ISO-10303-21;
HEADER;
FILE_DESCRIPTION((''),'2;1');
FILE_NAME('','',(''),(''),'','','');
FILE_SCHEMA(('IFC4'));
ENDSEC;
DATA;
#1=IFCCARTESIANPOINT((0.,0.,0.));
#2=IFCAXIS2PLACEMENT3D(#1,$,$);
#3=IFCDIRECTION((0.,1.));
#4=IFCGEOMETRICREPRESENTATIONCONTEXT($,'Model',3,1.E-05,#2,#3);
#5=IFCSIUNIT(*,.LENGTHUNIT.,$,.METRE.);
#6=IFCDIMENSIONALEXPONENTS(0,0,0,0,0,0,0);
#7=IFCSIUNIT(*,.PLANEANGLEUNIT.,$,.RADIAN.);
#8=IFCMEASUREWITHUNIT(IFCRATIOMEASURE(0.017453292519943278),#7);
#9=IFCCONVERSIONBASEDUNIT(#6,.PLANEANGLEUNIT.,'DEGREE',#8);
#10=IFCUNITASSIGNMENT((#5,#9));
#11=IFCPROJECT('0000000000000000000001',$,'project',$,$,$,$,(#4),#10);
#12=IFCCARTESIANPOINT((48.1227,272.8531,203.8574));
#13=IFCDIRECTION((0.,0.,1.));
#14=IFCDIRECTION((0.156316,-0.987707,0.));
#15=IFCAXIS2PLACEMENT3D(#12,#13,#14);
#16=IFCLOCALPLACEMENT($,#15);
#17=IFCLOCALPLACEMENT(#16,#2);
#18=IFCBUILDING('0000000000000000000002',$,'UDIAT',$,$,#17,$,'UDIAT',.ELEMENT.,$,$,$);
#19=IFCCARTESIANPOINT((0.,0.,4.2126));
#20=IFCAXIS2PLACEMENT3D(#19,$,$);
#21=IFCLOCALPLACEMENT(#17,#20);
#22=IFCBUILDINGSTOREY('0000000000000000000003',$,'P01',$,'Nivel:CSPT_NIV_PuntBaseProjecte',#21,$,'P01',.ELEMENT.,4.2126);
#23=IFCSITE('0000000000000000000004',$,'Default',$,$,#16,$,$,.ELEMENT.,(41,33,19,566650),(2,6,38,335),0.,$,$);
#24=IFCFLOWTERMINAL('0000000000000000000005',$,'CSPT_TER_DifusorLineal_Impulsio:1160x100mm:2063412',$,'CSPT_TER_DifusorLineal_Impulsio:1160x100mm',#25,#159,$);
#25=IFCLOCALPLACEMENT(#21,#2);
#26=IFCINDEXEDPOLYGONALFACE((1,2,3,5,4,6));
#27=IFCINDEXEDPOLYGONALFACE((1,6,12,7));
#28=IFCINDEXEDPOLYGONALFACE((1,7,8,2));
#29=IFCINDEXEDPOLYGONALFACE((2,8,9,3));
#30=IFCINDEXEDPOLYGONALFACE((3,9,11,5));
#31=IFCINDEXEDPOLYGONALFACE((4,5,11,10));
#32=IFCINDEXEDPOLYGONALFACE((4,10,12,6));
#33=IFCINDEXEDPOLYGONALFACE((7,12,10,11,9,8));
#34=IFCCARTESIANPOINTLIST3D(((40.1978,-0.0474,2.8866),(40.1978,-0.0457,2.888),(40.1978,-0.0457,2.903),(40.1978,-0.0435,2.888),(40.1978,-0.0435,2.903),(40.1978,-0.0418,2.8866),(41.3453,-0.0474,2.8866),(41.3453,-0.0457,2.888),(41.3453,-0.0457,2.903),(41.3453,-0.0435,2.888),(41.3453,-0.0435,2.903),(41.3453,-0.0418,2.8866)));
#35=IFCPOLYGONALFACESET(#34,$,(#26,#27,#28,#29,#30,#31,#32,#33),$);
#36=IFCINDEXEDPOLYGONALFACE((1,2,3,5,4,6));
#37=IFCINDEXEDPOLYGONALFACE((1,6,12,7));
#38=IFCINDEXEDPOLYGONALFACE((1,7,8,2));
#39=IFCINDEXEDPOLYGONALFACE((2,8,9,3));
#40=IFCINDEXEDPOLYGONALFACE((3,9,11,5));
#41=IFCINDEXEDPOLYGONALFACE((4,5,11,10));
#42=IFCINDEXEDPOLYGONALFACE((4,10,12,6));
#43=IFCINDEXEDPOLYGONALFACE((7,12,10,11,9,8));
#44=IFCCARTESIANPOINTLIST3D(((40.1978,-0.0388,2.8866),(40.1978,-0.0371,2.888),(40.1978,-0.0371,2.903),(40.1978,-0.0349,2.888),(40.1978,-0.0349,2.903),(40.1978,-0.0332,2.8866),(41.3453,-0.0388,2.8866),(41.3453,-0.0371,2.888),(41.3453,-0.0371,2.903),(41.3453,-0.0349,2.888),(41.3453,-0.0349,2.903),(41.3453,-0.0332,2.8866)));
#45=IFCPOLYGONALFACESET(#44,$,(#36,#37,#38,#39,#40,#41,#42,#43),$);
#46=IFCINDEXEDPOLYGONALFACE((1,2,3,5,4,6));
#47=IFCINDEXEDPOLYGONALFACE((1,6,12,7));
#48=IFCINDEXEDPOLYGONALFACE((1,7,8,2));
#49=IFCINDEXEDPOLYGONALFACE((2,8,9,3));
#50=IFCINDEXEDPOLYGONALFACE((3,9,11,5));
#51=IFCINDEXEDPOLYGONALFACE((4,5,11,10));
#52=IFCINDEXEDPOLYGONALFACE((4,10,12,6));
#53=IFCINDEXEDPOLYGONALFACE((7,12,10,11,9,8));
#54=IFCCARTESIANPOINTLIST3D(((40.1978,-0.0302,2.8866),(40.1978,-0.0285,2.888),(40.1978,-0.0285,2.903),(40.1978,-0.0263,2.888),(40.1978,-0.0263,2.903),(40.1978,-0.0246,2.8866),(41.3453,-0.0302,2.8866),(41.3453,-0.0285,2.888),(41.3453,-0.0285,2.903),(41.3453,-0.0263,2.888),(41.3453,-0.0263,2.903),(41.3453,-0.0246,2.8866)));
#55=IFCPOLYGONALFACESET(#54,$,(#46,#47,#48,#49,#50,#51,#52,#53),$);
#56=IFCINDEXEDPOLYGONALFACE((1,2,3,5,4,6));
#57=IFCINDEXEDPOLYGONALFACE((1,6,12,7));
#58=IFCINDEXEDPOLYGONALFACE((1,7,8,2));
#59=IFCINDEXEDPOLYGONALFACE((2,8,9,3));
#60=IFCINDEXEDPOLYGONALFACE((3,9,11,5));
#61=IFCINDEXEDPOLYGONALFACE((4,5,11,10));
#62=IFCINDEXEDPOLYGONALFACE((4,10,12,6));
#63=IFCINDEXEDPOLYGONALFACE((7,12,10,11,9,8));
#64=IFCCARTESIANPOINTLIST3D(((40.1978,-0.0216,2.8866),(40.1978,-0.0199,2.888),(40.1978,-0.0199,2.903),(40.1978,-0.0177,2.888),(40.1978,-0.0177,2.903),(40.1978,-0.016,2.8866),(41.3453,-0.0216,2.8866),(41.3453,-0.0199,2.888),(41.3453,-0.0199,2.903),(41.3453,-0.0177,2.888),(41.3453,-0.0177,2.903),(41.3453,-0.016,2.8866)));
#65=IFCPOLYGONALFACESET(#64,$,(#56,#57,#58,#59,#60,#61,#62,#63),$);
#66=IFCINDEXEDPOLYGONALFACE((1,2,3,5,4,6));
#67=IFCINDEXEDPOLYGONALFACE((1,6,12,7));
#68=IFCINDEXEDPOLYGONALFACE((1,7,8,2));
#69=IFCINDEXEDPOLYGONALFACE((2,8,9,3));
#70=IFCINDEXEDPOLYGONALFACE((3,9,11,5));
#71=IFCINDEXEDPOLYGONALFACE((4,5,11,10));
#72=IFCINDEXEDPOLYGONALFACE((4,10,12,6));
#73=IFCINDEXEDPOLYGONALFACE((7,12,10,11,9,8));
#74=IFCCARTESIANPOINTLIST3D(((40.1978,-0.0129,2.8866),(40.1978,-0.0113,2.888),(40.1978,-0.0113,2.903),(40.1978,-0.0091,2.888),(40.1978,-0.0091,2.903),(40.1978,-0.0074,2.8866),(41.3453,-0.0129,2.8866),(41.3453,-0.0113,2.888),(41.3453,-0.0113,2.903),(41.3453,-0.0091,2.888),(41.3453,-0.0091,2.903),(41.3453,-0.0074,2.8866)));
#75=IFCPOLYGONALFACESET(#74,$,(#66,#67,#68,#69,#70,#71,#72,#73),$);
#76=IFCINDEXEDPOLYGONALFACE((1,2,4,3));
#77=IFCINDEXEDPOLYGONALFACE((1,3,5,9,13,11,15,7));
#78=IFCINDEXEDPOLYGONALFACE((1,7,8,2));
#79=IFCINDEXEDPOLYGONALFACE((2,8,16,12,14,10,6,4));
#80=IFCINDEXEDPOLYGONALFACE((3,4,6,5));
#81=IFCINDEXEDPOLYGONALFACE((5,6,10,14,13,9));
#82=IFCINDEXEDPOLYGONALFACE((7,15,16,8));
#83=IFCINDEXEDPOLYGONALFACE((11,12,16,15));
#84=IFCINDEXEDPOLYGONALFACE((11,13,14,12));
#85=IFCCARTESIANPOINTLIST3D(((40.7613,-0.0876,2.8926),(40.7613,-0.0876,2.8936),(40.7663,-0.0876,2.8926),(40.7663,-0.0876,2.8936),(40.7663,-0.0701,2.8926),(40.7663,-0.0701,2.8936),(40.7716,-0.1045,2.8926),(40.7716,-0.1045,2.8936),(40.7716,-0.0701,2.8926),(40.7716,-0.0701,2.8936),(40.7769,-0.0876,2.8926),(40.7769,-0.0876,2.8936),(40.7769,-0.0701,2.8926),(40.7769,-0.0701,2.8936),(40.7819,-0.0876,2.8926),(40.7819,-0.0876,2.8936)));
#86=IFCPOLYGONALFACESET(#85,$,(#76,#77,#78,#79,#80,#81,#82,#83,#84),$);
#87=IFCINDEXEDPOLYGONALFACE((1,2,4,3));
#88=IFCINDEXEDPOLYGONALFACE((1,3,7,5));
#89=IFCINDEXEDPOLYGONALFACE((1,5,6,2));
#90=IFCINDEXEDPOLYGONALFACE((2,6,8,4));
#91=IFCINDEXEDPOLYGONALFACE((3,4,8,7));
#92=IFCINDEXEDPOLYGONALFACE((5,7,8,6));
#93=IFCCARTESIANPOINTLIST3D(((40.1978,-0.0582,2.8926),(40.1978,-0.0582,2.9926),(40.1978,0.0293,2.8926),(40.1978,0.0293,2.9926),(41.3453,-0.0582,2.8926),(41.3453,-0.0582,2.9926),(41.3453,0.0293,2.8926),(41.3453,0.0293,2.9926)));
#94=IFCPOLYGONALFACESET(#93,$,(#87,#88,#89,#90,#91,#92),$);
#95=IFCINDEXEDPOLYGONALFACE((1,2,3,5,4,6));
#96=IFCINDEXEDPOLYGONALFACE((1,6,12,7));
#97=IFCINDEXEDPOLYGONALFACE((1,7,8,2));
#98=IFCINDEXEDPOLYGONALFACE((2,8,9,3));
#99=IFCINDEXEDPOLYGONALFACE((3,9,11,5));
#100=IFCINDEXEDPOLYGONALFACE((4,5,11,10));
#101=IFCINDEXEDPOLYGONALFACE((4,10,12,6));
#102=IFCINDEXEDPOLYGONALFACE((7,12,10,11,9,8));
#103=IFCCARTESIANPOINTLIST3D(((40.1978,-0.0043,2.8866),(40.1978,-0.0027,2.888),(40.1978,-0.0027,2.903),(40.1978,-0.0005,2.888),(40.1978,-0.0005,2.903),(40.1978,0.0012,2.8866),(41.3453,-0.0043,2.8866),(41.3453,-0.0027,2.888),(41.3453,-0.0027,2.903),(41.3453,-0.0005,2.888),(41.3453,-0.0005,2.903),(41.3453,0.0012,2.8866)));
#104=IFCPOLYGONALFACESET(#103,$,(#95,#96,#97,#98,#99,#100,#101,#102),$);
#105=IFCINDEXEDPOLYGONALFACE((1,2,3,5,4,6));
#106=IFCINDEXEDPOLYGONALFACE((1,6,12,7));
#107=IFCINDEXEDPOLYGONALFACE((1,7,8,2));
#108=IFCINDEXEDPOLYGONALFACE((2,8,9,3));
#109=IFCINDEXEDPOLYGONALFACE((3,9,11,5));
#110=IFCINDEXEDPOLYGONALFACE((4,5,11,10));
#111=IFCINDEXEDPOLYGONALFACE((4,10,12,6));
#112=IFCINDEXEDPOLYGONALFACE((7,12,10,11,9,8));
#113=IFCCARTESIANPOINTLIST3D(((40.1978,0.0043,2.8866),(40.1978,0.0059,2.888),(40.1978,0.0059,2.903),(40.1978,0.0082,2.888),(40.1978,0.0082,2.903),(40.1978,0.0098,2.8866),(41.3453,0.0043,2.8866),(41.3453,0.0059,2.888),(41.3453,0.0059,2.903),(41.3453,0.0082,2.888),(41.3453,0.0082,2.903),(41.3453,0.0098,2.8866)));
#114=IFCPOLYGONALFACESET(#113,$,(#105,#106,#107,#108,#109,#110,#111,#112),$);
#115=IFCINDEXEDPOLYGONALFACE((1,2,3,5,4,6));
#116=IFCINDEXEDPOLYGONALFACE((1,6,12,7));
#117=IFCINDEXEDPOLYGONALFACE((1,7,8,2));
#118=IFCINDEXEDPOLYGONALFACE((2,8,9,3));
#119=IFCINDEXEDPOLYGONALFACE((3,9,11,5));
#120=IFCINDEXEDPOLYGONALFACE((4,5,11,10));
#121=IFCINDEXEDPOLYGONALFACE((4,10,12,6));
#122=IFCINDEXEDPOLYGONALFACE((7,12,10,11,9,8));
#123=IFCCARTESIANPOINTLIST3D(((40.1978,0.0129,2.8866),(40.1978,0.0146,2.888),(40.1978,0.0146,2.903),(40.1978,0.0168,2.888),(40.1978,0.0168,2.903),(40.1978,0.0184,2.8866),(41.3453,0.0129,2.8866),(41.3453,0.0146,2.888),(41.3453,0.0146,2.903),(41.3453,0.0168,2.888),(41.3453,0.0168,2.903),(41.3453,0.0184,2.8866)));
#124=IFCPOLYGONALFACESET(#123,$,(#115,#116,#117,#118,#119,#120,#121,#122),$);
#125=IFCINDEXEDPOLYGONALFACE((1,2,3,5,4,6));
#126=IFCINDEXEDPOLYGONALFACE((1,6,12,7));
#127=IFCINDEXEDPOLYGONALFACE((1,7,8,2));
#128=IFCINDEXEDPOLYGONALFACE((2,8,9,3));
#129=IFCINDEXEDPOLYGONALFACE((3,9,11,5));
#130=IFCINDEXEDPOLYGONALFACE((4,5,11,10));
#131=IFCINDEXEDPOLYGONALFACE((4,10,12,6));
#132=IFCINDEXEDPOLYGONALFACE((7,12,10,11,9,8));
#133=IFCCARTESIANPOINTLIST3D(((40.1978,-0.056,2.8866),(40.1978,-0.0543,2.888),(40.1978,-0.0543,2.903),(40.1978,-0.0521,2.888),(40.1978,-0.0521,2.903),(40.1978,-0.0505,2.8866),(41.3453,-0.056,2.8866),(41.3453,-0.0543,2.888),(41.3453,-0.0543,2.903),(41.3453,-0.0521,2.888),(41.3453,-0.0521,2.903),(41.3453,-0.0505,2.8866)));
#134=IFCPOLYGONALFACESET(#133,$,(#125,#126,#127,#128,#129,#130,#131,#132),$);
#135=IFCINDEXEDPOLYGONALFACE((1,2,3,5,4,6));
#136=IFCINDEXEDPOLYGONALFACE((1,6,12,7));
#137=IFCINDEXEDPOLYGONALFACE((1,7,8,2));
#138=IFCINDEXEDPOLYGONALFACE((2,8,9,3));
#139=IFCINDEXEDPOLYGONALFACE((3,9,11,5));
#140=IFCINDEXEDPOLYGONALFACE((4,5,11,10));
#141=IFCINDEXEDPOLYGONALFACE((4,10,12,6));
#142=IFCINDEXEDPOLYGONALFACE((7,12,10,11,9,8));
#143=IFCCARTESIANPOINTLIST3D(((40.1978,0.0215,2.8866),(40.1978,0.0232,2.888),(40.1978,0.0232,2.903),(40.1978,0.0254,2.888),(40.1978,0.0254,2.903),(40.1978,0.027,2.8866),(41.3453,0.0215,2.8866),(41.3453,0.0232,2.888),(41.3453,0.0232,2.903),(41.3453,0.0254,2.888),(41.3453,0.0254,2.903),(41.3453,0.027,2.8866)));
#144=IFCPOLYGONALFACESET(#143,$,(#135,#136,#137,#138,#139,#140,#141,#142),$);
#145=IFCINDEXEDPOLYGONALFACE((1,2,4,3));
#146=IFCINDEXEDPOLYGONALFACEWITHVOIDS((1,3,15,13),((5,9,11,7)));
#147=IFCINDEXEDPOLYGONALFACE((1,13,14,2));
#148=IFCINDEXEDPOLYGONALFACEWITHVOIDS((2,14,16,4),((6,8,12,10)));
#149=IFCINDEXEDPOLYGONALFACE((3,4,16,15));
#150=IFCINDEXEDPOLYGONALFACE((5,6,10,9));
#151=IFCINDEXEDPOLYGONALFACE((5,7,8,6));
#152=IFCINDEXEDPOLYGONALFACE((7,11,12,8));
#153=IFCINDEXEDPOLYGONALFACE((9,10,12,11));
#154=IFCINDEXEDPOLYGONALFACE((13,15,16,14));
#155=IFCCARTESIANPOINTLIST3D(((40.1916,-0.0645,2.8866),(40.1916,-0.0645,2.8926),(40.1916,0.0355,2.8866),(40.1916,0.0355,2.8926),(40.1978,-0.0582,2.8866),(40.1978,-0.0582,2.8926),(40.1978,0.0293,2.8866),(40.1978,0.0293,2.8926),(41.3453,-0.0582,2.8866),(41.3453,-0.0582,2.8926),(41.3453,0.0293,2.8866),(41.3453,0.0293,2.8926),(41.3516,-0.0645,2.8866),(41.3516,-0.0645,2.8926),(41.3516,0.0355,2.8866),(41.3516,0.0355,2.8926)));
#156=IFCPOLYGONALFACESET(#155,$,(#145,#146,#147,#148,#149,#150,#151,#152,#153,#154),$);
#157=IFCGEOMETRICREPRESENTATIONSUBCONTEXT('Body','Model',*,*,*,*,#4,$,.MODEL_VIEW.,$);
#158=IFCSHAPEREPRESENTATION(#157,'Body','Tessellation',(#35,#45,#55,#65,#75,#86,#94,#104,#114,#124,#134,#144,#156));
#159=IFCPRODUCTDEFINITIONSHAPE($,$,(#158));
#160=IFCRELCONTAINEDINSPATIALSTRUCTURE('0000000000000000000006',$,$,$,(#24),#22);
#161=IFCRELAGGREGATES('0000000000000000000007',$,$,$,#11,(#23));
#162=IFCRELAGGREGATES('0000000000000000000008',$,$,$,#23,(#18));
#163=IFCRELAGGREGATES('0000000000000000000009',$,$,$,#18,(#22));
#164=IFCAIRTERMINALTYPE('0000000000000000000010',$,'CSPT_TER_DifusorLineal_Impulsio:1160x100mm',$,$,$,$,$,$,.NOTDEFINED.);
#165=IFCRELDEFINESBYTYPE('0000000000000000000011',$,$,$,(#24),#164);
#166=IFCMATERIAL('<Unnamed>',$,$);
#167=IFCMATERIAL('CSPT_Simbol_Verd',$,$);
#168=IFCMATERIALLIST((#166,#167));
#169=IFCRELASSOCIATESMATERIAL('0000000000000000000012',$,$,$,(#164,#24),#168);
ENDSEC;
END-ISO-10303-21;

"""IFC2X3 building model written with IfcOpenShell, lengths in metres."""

from ifc_helpers import new_model, entity, si_unit, converted_unit, direction, frame, origin, origin_2d_with_axis, place, context, subcontext, project, spatial, polyline, rectangle, outline, extrude, source, transform, mapped, material, material_list, type_object, type_shapes, element, save


model = new_model("IFC2X3")

# Units and contexts
model_context = context("Model", 3, precision=1e-05, world=origin(), true_north=direction((0.0, 1.0)))
body_context = subcontext(model_context, "Body", "Model", "MODEL_VIEW")
ifc_project = project(units=[si_unit("LENGTHUNIT", "METRE"), converted_unit("PLANEANGLEUNIT", "DEGREE", entity("IfcRatioMeasure", 0.017453292519943278), si_unit("PLANEANGLEUNIT", "RADIAN"), dimensions=[0, 0, 0, 0, 0, 0, 0])], contexts=[model_context])

# Site, building, storey
site_placement = place(None, frame((48.1227, 272.8531, 203.8574), z_axis=(0.0, 0.0, 1.0), x_axis=(0.156316, -0.987707, 0.0)))
site = spatial("IfcSite", under=ifc_project, at=site_placement, Name="Default", CompositionType="ELEMENT", RefLatitude=(41, 33, 19, 566650), RefLongitude=(2, 6, 38, 335), RefElevation=0.0)
building_placement = place(site_placement, origin())
building = spatial("IfcBuilding", under=site, at=building_placement, Name="UDIAT", LongName="UDIAT", CompositionType="ELEMENT")
storey_placement = place(building_placement, frame((0.0, 0.0, 4.2126)))
storey = spatial("IfcBuildingStorey", under=building, at=storey_placement, Name="P01", ObjectType="Nivel:CSPT_NIV_PuntBaseProjecte", LongName="P01", CompositionType="ELEMENT", Elevation=4.2126)

# Shared definitions
ifc_material_1 = material(Name="<Unnamed>")

# Flow terminal
ifc_material_2 = material(Name="CSPT_Simbol_Verd")
ifc_material_list = material_list([ifc_material_1, ifc_material_2])
air_terminal_type = type_object("IfcAirTerminalType", Name="CSPT_TER_DifusorLineal_Impulsio:1160x100mm", PredefinedType="NOTDEFINED", material=ifc_material_list)
shared_shape_1 = source(origin(), body_context, "Body", "SweptSolid", [
    extrude(outline(polyline([(0.0037, 0.0028), (0.0059, 0.0028), (0.0016, 0.0063), (0.002, 0.0042), (-0.0074, -0.0074), (-0.0057, -0.0088), (0.0037, 0.0028)])), frame((-0.5737, 0.0301, -0.0001), z_axis=(1.0, 0.0, 0.0), x_axis=(0.0, -0.776119, -0.630587)), (0.0, 0.0, 1.0), 1.1475),
    extrude(outline(polyline([(0.0037, 0.0028), (0.0059, 0.0028), (0.0016, 0.0063), (0.002, 0.0042), (-0.0074, -0.0074), (-0.0057, -0.0088), (0.0037, 0.0028)])), frame((-0.5737, 0.0215, -0.0001), z_axis=(1.0, 0.0, 0.0), x_axis=(0.0, -0.776119, -0.630587)), (0.0, 0.0, 1.0), 1.1475),
    extrude(outline(polyline([(0.0037, 0.0028), (0.0059, 0.0028), (0.0016, 0.0063), (0.002, 0.0042), (-0.0074, -0.0074), (-0.0057, -0.0088), (0.0037, 0.0028)])), frame((-0.5737, 0.0129, -0.0001), z_axis=(1.0, 0.0, 0.0), x_axis=(0.0, -0.776119, -0.630587)), (0.0, 0.0, 1.0), 1.1475),
    extrude(outline(polyline([(0.0037, 0.0028), (0.0059, 0.0028), (0.0016, 0.0063), (0.002, 0.0042), (-0.0074, -0.0074), (-0.0057, -0.0088), (0.0037, 0.0028)])), frame((-0.5737, 0.0043, -0.0001), z_axis=(1.0, 0.0, 0.0), x_axis=(0.0, -0.776119, -0.630587)), (0.0, 0.0, 1.0), 1.1475),
    extrude(outline(polyline([(0.0037, 0.0028), (0.0059, 0.0028), (0.0016, 0.0063), (0.002, 0.0042), (-0.0074, -0.0074), (-0.0057, -0.0088), (0.0037, 0.0028)])), frame((-0.5737, -0.0043, -0.0001), z_axis=(1.0, 0.0, 0.0), x_axis=(0.0, -0.776119, -0.630587)), (0.0, 0.0, 1.0), 1.1475),
    extrude(outline(polyline([(0.0, -0.013), (0.0053, -0.013), (0.0053, 0.0045), (0.0103, 0.0045), (0.0, 0.0213), (-0.0103, 0.0045), (-0.0053, 0.0045), (-0.0053, -0.013), (0.0, -0.013)])), frame((0.0, 0.0687, 0.0)), (0.0, 0.0, 1.0), 0.001),
    extrude(rectangle(XDim=1.1475, YDim=0.0875, at=origin_2d_with_axis()), frame((0.0, 0.0, 0.0), z_axis=(0.0, 0.0, 1.0), x_axis=(-1.0, 0.0, 0.0)), (0.0, 0.0, 1.0), 0.1),
    extrude(outline(polyline([(0.0037, 0.0028), (0.0059, 0.0028), (0.0016, 0.0063), (0.002, 0.0042), (-0.0074, -0.0074), (-0.0057, -0.0088), (0.0037, 0.0028)])), frame((-0.5737, -0.0129, -0.0001), z_axis=(1.0, 0.0, 0.0), x_axis=(0.0, -0.776119, -0.630587)), (0.0, 0.0, 1.0), 1.1475),
    extrude(outline(polyline([(0.0037, 0.0028), (0.0059, 0.0028), (0.0016, 0.0063), (0.002, 0.0042), (-0.0074, -0.0074), (-0.0057, -0.0088), (0.0037, 0.0028)])), frame((-0.5737, -0.0215, -0.0001), z_axis=(1.0, 0.0, 0.0), x_axis=(0.0, -0.776119, -0.630587)), (0.0, 0.0, 1.0), 1.1475),
    extrude(outline(polyline([(0.0037, 0.0028), (0.0059, 0.0028), (0.0016, 0.0063), (0.002, 0.0042), (-0.0074, -0.0074), (-0.0057, -0.0088), (0.0037, 0.0028)])), frame((-0.5737, -0.0301, -0.0001), z_axis=(1.0, 0.0, 0.0), x_axis=(0.0, -0.776119, -0.630587)), (0.0, 0.0, 1.0), 1.1475),
    extrude(outline(polyline([(0.0037, 0.0028), (0.0059, 0.0028), (0.0016, 0.0063), (0.002, 0.0042), (-0.0074, -0.0074), (-0.0057, -0.0088), (0.0037, 0.0028)])), frame((-0.5737, 0.0388, -0.0001), z_axis=(1.0, 0.0, 0.0), x_axis=(0.0, -0.776119, -0.630587)), (0.0, 0.0, 1.0), 1.1475),
    extrude(outline(polyline([(0.0037, 0.0028), (0.0059, 0.0028), (0.0016, 0.0063), (0.002, 0.0042), (-0.0074, -0.0074), (-0.0057, -0.0088), (0.0037, 0.0028)])), frame((-0.5737, -0.0387, -0.0001), z_axis=(1.0, 0.0, 0.0), x_axis=(0.0, -0.776119, -0.630587)), (0.0, 0.0, 1.0), 1.1475),
    extrude(outline(polyline([(-0.58, -0.05), (0.58, -0.05), (0.58, 0.05), (-0.58, 0.05), (-0.58, -0.05)]), holes=[polyline([(-0.5738, -0.0438), (-0.5738, 0.0437), (0.5737, 0.0437), (0.5737, -0.0438), (-0.5738, -0.0438)])]), frame((0.0, 0.0, -0.006), z_axis=(0.0, 0.0, 1.0), x_axis=(-1.0, 0.0, 0.0)), (0.0, 0.0, 1.0), 0.006),
])
type_shapes(air_terminal_type, [shared_shape_1])
for number, where, z_axis, x_axis, name in (
    (1, (40.7716, -0.0145, 2.8926), (0.0, 0.0, 1.0), (-1.0, 0.0, 0.0), "CSPT_TER_DifusorLineal_Impulsio:1160x100mm:2063412"),
):
    element("IfcFlowTerminal", number, at=place(storey_placement, frame(where, z_axis=z_axis, x_axis=x_axis)), inside=storey, type_object=air_terminal_type, material=ifc_material_list, Name=name, ObjectType="CSPT_TER_DifusorLineal_Impulsio:1160x100mm", context=body_context, shape_type="MappedRepresentation", body=[
        mapped(shared_shape_1, transform((0.0, 0.0, 0.0), scale=1.0)),
    ])

save(model, "model.ifc")
